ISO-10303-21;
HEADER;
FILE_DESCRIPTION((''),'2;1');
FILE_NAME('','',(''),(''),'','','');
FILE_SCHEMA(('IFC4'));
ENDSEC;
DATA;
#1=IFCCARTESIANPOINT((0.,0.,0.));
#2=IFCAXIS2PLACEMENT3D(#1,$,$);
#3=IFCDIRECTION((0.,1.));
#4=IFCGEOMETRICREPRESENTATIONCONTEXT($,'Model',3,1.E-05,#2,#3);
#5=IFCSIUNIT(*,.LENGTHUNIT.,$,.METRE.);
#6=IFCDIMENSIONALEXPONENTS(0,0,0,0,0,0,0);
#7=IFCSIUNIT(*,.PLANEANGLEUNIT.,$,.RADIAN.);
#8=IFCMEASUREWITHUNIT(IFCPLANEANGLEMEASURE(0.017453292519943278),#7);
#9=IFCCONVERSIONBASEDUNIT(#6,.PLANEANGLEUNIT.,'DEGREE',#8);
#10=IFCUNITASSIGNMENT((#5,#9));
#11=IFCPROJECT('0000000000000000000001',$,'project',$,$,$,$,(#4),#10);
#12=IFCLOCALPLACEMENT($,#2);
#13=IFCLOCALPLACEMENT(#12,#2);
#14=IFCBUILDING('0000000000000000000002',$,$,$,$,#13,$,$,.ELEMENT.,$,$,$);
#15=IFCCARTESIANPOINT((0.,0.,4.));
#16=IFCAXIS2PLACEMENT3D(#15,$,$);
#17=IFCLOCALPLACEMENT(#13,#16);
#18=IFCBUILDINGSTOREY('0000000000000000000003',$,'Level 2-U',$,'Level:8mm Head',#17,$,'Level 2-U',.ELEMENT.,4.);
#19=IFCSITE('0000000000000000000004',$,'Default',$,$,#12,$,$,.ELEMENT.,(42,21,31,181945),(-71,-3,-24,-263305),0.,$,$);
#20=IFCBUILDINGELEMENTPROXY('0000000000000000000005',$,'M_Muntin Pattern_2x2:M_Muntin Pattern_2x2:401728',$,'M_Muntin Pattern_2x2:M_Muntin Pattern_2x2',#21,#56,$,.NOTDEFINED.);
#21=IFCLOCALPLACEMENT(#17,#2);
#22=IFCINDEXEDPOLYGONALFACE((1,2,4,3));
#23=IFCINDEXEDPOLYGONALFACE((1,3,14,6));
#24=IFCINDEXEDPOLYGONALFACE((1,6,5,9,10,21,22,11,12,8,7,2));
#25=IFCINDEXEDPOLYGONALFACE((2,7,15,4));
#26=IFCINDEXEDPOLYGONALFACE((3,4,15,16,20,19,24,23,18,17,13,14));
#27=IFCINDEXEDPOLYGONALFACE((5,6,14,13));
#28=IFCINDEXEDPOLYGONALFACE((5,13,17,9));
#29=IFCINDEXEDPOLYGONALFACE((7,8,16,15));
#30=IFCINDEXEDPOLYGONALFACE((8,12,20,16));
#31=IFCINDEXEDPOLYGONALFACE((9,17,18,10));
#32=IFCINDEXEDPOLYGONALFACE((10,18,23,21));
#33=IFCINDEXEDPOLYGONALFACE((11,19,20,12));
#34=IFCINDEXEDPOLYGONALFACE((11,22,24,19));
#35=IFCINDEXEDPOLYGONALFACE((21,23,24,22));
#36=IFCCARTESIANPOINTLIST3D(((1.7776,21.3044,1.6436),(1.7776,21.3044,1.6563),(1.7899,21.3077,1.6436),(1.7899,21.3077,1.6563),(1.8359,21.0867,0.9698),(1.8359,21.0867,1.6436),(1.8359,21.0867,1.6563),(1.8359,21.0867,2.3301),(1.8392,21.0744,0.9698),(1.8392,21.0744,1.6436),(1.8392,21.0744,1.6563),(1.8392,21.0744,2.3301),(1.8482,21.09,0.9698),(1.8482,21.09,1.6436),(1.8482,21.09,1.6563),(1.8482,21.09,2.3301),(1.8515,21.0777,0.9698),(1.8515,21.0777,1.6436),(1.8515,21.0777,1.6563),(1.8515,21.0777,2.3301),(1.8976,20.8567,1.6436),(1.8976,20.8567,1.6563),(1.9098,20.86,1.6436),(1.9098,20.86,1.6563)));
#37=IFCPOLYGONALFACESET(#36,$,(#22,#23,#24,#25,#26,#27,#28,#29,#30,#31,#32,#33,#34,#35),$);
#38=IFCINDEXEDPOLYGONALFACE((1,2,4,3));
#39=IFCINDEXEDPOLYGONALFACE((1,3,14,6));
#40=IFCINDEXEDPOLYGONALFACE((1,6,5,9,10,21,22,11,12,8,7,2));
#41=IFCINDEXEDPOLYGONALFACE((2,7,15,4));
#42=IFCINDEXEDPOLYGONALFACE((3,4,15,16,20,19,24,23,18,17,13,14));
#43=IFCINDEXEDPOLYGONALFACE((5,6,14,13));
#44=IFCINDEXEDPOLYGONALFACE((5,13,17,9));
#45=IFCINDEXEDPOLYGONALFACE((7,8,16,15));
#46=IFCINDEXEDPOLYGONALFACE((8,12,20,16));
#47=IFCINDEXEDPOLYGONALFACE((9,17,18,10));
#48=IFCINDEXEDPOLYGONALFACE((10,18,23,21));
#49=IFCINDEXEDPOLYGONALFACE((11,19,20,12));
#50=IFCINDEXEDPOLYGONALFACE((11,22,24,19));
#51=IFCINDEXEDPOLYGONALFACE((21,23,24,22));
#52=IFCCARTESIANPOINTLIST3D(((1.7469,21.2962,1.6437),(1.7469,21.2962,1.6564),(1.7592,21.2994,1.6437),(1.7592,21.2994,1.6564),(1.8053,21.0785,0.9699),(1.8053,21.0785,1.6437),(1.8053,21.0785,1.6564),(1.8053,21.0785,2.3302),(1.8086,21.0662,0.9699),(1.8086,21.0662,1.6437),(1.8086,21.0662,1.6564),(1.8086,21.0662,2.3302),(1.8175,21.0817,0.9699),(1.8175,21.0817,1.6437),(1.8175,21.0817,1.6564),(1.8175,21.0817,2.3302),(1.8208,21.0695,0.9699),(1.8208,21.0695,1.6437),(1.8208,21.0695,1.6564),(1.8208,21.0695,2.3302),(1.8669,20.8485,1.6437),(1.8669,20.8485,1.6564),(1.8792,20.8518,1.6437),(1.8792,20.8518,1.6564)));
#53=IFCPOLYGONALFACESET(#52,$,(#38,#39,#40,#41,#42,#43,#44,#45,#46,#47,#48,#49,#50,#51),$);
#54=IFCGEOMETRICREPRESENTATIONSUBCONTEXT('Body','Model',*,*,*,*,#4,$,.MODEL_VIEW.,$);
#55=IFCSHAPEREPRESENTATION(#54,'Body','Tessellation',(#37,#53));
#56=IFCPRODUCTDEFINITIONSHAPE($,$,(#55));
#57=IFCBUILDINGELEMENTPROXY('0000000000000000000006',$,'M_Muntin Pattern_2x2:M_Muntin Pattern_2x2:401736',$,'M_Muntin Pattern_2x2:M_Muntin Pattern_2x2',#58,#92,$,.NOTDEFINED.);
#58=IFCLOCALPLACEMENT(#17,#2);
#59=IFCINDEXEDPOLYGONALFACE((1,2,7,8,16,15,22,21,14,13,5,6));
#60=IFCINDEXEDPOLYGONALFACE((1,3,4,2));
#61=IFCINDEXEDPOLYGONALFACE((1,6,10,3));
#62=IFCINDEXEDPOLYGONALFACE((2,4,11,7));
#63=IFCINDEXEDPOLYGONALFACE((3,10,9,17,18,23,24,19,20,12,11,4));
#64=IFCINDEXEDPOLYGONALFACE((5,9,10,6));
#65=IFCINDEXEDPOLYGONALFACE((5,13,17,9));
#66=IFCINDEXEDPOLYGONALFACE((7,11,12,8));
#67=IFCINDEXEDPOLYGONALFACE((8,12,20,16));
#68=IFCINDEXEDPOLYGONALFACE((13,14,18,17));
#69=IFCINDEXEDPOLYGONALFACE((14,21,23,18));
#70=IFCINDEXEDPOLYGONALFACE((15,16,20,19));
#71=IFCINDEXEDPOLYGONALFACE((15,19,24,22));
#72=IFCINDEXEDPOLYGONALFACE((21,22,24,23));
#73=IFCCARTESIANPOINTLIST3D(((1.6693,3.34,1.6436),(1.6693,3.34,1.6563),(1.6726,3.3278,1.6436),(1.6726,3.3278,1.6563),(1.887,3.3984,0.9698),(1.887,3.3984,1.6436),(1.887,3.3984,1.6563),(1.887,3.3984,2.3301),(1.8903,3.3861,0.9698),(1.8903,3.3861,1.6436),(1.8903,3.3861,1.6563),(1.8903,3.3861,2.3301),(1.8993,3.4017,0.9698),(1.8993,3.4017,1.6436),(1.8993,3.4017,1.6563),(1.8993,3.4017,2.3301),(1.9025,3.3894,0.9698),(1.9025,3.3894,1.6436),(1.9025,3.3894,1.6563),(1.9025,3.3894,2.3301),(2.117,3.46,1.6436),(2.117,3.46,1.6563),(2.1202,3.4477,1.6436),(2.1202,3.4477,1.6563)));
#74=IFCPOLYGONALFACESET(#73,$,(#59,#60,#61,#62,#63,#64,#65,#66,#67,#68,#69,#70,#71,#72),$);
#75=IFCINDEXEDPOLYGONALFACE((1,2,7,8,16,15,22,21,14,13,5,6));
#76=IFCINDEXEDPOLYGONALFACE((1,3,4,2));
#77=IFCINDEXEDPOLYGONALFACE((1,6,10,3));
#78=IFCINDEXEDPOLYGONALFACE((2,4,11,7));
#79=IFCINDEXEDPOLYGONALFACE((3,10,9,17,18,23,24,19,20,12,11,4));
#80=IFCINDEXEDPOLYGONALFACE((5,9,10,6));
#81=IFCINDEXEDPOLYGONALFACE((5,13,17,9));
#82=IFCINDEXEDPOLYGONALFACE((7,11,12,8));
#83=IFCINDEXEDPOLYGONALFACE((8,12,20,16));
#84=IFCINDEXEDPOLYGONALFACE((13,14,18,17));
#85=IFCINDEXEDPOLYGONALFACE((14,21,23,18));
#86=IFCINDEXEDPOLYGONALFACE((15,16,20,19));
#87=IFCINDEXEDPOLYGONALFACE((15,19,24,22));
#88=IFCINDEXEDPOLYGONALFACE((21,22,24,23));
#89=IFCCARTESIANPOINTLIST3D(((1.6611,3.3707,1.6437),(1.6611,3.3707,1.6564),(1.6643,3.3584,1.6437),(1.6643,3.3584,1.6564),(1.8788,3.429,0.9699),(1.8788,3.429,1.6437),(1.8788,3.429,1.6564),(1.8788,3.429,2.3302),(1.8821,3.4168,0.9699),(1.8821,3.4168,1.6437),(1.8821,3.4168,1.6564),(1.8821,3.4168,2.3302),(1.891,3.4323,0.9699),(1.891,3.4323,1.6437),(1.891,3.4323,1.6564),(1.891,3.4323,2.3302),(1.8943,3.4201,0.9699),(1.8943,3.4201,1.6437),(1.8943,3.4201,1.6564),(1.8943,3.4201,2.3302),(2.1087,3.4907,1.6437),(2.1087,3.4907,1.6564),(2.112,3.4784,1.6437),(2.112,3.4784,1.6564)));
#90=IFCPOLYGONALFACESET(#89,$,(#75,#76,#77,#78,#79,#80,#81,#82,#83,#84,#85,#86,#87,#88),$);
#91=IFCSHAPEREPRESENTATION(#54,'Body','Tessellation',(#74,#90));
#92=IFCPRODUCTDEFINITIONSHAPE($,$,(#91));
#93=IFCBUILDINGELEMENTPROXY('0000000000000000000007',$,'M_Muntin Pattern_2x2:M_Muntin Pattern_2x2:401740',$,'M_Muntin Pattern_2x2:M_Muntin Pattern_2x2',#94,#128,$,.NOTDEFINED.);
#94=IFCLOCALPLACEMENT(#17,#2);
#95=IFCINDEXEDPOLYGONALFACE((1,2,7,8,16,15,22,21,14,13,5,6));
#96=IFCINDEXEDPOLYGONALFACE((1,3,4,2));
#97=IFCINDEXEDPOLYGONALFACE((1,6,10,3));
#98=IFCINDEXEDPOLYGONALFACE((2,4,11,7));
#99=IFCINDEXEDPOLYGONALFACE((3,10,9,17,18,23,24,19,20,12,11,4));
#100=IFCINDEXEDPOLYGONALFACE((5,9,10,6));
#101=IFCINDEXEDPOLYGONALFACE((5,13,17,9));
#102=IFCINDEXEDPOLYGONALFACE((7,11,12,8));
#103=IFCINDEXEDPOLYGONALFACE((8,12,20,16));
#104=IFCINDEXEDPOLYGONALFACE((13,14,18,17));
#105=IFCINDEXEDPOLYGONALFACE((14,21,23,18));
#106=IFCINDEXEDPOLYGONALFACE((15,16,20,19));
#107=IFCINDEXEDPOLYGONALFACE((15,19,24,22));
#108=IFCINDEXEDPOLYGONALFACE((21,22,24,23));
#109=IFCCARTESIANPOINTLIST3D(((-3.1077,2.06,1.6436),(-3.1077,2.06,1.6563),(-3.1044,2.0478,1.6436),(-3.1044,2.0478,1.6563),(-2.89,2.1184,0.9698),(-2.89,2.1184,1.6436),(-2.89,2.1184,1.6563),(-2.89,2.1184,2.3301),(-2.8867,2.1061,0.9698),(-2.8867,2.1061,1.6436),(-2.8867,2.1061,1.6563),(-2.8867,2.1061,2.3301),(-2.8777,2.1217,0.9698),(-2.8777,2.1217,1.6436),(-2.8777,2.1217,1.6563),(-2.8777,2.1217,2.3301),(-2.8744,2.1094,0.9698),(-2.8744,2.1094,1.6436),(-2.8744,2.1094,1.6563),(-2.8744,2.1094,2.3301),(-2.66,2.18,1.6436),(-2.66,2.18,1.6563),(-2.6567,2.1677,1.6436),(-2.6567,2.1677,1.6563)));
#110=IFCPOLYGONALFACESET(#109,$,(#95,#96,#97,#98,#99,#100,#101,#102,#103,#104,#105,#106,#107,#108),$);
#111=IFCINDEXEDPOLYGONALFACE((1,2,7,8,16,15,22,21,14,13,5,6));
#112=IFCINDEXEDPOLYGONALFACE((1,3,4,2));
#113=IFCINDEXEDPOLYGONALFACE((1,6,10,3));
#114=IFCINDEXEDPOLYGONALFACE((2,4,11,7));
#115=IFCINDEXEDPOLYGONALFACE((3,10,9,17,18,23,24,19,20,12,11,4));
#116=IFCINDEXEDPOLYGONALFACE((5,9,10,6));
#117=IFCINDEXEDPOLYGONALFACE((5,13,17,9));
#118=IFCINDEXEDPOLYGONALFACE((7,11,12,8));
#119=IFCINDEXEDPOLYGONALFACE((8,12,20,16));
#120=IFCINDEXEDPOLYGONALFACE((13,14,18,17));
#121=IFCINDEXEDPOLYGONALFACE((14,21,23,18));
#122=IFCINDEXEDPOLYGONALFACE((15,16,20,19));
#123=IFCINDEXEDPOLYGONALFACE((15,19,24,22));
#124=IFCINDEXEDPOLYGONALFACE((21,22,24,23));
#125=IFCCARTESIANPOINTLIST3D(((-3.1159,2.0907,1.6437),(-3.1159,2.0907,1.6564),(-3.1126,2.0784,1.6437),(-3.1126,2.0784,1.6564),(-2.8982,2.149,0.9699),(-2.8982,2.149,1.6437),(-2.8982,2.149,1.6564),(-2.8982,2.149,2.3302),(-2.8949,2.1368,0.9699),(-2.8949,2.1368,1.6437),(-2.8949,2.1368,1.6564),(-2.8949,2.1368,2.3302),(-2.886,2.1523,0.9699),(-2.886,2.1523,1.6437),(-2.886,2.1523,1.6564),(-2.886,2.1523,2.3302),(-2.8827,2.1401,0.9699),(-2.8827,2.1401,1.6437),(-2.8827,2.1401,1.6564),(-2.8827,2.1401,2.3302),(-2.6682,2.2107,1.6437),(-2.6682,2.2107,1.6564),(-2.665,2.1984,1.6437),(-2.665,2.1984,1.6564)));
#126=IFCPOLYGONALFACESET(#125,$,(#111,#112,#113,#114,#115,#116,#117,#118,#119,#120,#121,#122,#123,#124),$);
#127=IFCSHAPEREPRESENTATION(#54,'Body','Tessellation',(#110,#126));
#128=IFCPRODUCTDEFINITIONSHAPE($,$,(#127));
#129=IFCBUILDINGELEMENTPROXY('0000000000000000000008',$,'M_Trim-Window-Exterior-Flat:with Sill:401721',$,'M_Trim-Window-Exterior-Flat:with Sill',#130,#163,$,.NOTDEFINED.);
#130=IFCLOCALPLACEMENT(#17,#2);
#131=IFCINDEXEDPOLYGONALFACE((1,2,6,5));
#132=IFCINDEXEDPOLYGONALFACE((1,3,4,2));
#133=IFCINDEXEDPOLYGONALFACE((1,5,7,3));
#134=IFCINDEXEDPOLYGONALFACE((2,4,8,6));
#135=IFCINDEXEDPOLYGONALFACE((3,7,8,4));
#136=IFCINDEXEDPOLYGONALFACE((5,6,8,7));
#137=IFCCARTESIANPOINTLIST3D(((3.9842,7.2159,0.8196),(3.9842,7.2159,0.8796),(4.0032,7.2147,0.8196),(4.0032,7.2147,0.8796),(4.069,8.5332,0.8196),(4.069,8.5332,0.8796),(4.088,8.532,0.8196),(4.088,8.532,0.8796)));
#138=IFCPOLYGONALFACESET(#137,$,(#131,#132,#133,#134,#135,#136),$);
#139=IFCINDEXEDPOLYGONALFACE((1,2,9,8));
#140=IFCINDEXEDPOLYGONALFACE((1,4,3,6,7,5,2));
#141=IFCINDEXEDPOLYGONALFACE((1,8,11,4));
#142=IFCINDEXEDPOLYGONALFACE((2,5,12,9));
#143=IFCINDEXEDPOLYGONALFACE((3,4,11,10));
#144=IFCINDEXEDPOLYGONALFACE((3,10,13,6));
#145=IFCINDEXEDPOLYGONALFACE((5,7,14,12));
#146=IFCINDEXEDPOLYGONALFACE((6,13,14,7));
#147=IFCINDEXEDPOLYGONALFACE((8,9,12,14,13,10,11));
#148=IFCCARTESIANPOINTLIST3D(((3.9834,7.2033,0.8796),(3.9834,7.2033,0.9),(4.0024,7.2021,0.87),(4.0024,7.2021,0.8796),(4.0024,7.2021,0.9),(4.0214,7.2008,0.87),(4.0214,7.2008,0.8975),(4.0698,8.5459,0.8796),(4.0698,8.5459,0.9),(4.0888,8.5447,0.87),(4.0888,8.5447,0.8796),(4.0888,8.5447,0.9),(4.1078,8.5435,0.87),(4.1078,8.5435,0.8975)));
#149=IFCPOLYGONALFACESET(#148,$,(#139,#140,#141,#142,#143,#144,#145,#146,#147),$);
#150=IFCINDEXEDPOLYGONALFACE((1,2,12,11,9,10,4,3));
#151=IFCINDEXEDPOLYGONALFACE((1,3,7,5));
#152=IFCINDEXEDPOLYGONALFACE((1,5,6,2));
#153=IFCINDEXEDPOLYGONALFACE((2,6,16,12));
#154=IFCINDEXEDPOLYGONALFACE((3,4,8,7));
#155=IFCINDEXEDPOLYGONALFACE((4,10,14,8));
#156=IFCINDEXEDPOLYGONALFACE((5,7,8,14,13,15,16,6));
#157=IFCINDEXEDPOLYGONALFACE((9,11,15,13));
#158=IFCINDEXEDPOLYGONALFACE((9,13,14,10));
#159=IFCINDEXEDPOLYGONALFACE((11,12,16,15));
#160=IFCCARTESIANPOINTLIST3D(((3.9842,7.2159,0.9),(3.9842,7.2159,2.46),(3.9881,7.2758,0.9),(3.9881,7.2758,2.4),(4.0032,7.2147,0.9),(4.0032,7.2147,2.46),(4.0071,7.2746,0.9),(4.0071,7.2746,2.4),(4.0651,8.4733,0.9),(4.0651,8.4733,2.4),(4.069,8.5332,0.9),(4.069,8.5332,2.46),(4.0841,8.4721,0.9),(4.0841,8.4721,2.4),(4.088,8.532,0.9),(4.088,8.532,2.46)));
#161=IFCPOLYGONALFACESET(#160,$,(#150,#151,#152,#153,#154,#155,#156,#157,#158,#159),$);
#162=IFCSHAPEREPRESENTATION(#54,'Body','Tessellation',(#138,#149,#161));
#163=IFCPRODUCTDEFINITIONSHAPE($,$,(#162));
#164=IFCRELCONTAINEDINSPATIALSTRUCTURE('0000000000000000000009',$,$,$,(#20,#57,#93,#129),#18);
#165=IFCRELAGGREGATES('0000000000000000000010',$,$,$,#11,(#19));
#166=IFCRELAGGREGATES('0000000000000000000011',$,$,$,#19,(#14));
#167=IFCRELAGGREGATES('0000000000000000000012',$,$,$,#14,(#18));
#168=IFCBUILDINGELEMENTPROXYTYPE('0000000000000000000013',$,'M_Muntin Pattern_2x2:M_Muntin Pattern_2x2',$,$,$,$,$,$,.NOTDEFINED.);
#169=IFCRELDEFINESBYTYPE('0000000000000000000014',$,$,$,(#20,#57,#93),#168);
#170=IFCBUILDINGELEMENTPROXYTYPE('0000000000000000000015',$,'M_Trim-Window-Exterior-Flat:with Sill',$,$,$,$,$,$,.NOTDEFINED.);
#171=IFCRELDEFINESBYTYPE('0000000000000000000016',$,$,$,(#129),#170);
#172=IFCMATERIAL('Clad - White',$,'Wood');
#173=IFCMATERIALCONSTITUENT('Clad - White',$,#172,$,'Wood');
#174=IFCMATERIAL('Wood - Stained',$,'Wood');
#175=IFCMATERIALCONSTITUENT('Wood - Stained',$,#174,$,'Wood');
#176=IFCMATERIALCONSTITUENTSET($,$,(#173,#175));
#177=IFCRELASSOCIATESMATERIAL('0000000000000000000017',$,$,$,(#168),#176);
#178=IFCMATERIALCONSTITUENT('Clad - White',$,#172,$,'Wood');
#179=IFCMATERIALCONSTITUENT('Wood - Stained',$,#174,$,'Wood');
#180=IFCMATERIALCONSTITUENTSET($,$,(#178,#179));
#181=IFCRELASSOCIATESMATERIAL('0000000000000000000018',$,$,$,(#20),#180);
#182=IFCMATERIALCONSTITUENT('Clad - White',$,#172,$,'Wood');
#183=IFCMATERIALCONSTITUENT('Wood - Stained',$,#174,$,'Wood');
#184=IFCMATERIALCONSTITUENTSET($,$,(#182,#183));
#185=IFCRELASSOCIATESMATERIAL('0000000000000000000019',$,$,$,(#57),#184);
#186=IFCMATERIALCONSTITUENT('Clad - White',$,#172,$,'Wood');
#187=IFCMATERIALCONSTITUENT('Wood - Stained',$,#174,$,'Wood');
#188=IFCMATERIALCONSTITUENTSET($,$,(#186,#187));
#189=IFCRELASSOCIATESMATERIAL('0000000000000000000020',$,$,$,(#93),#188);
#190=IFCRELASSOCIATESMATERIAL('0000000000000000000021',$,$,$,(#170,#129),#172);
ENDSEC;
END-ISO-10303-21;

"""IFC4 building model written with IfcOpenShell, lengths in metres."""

from ifc_helpers import new_model, entity, si_unit, converted_unit, direction, frame, frame_2d, origin, place, context, subcontext, project, spatial, polyline, rectangle, outline, extrude, source, transform, mapped, material, constituent, constituent_set, type_object, type_shapes, element, save


model = new_model("IFC4")

# Units and contexts
model_context = context("Model", 3, precision=1e-05, world=origin(), true_north=direction((0.0, 1.0)))
body_context = subcontext(model_context, "Body", "Model", "MODEL_VIEW")
ifc_project = project(units=[si_unit("LENGTHUNIT", "METRE"), converted_unit("PLANEANGLEUNIT", "DEGREE", entity("IfcPlaneAngleMeasure", 0.017453292519943278), si_unit("PLANEANGLEUNIT", "RADIAN"), dimensions=[0, 0, 0, 0, 0, 0, 0])], contexts=[model_context])

# Site, building, storey
site_placement = place(None, origin())
site = spatial("IfcSite", under=ifc_project, at=site_placement, Name="Default", CompositionType="ELEMENT", RefLatitude=(42, 21, 31, 181945), RefLongitude=(-71, -3, -24, -263305), RefElevation=0.0)
building_placement = place(site_placement, origin())
building = spatial("IfcBuilding", under=site, at=building_placement, CompositionType="ELEMENT")
storey_placement = place(building_placement, frame((0.0, 0.0, 4.0)))
storey = spatial("IfcBuildingStorey", under=building, at=storey_placement, Name="Level 2-U", ObjectType="Level:8mm Head", LongName="Level 2-U", CompositionType="ELEMENT", Elevation=4.0)

# Building element proxies
ifc_material_1 = material(Name="Clad - White", Category="Wood")
ifc_material_2 = material(Name="Wood - Stained", Category="Wood")
ifc_constituent_1 = constituent(ifc_material_1, Name="Clad - White", Category="Wood")
ifc_constituent_2 = constituent(ifc_material_2, Name="Wood - Stained", Category="Wood")
ifc_constituent_set_1 = constituent_set(constituents=[ifc_constituent_1, ifc_constituent_2])
building_element_proxy_type_1 = type_object("IfcBuildingElementProxyType", Name="M_Muntin Pattern_2x2:M_Muntin Pattern_2x2", PredefinedType="NOTDEFINED", material=ifc_constituent_set_1)
shared_shape_1 = source(origin(), body_context, "Body", "SweptSolid", [
    extrude(outline(polyline([(0.0064, -0.0064), (0.6801, -0.0064), (0.6801, 0.0063), (0.0064, 0.0063), (0.0064, 0.2317), (-0.0063, 0.2317), (-0.0063, 0.0063), (-0.6802, 0.0063), (-0.6802, -0.0064), (-0.0063, -0.0064), (-0.0063, -0.2317), (0.0064, -0.2317), (0.0064, -0.0064)])), frame((0.0, -0.0222, 0.6801), z_axis=(0.0, 1.0, 0.0), x_axis=(0.0, 0.0, 1.0)), (0.0, 0.0, 1.0), 0.0127),
    extrude(outline(polyline([(0.0064, -0.0064), (0.6802, -0.0064), (0.6802, 0.0063), (0.0064, 0.0063), (0.0064, 0.2317), (-0.0063, 0.2317), (-0.0063, 0.0063), (-0.6802, 0.0063), (-0.6802, -0.0064), (-0.0063, -0.0064), (-0.0063, -0.2317), (0.0064, -0.2317), (0.0064, -0.0064)])), frame((0.0, 0.0095, 0.6802), z_axis=(0.0, 1.0, 0.0), x_axis=(0.0, 0.0, 1.0)), (0.0, 0.0, 1.0), 0.0127),
])
type_shapes(building_element_proxy_type_1, [shared_shape_1])
ifc_constituent_3 = constituent(ifc_material_1, Name="Clad - White", Category="Wood")
ifc_constituent_4 = constituent(ifc_material_2, Name="Wood - Stained", Category="Wood")
ifc_constituent_set_2 = constituent_set(constituents=[ifc_constituent_3, ifc_constituent_4])
proxy_1_placement = place(storey_placement, frame((1.8284, 21.0781, 0.9699), z_axis=(0.0, 0.0, 1.0), x_axis=(-0.258819, 0.965926, 0.0)))
element("IfcBuildingElementProxy", 1, at=proxy_1_placement, inside=storey, type_object=building_element_proxy_type_1, material=ifc_constituent_set_2, Name="M_Muntin Pattern_2x2:M_Muntin Pattern_2x2:401728", ObjectType="M_Muntin Pattern_2x2:M_Muntin Pattern_2x2", PredefinedType="NOTDEFINED", context=body_context, shape_type="MappedRepresentation", body=[
    mapped(shared_shape_1, transform((0.0, 0.0, 0.0), scale=1.0)),
])
ifc_constituent_5 = constituent(ifc_material_1, Name="Clad - White", Category="Wood")
ifc_constituent_6 = constituent(ifc_material_2, Name="Wood - Stained", Category="Wood")
ifc_constituent_set_3 = constituent_set(constituents=[ifc_constituent_5, ifc_constituent_6])
proxy_2_placement = place(storey_placement, frame((1.8907, 3.4092, 0.9699), z_axis=(0.0, 0.0, 1.0), x_axis=(0.965926, 0.258819, 0.0)))
element("IfcBuildingElementProxy", 2, at=proxy_2_placement, inside=storey, type_object=building_element_proxy_type_1, material=ifc_constituent_set_3, Name="M_Muntin Pattern_2x2:M_Muntin Pattern_2x2:401736", ObjectType="M_Muntin Pattern_2x2:M_Muntin Pattern_2x2", PredefinedType="NOTDEFINED", context=body_context, shape_type="MappedRepresentation", body=[
    mapped(shared_shape_1, transform((0.0, 0.0, 0.0), scale=1.0)),
])
ifc_constituent_7 = constituent(ifc_material_1, Name="Clad - White", Category="Wood")
ifc_constituent_8 = constituent(ifc_material_2, Name="Wood - Stained", Category="Wood")
ifc_constituent_set_4 = constituent_set(constituents=[ifc_constituent_7, ifc_constituent_8])
proxy_3_placement = place(storey_placement, frame((-2.8863, 2.1292, 0.9699), z_axis=(0.0, 0.0, 1.0), x_axis=(0.965926, 0.258819, 0.0)))
element("IfcBuildingElementProxy", 3, at=proxy_3_placement, inside=storey, type_object=building_element_proxy_type_1, material=ifc_constituent_set_4, Name="M_Muntin Pattern_2x2:M_Muntin Pattern_2x2:401740", ObjectType="M_Muntin Pattern_2x2:M_Muntin Pattern_2x2", PredefinedType="NOTDEFINED", context=body_context, shape_type="MappedRepresentation", body=[
    mapped(shared_shape_1, transform((0.0, 0.0, 0.0), scale=1.0)),
])
building_element_proxy_type_2 = type_object("IfcBuildingElementProxyType", Name="M_Trim-Window-Exterior-Flat:with Sill", PredefinedType="NOTDEFINED", material=ifc_material_1)
shared_shape_2 = source(origin(), body_context, "Body", "SweptSolid", [
    extrude(rectangle(XDim=1.32, YDim=0.06, at=frame_2d((0.0, 0.0), x_axis=(1.0, 0.0))), frame((0.0, -1.5504, 0.0), z_axis=(0.0, 0.0, 1.0), x_axis=(-1.0, 0.0, 0.0)), (0.0, 0.0, 1.0), 0.019),
    extrude(outline(polyline([(-0.019, -0.0152), (0.0, -0.0152), (0.0, -0.0057), (0.019, -0.0057), (0.019, 0.0148), (0.0, 0.0148), (-0.019, 0.0123), (-0.019, -0.0152)])), frame((-0.6727, -1.5148, 0.019), z_axis=(1.0, 0.0, 0.0), x_axis=(0.0, 0.0, -1.0)), (0.0, 0.0, 1.0), 1.3454),
    extrude(outline(polyline([(-0.795, -0.66), (0.765, -0.66), (0.765, -0.6), (-0.735, -0.6), (-0.735, 0.6), (0.765, 0.6), (0.765, 0.66), (-0.795, 0.66), (-0.795, -0.66)])), frame((0.0, -0.735, 0.0), z_axis=(0.0, 0.0, 1.0), x_axis=(0.0, -1.0, 0.0)), (0.0, 0.0, 1.0), 0.019),
])
type_shapes(building_element_proxy_type_2, [shared_shape_2])
for number, where, z_axis, x_axis, name in (
    (4, (4.0266, 7.8746, 2.4), (0.997938, -0.064186, 0.0), (0.064186, 0.997938, 0.0), "M_Trim-Window-Exterior-Flat:with Sill:401721"),
):
    element("IfcBuildingElementProxy", number, at=place(storey_placement, frame(where, z_axis=z_axis, x_axis=x_axis)), inside=storey, type_object=building_element_proxy_type_2, material=ifc_material_1, Name=name, ObjectType="M_Trim-Window-Exterior-Flat:with Sill", PredefinedType="NOTDEFINED", context=body_context, shape_type="MappedRepresentation", body=[
        mapped(shared_shape_2, transform((0.0, 0.0, 0.0), scale=1.0)),
    ])

save(model, "model.ifc")
